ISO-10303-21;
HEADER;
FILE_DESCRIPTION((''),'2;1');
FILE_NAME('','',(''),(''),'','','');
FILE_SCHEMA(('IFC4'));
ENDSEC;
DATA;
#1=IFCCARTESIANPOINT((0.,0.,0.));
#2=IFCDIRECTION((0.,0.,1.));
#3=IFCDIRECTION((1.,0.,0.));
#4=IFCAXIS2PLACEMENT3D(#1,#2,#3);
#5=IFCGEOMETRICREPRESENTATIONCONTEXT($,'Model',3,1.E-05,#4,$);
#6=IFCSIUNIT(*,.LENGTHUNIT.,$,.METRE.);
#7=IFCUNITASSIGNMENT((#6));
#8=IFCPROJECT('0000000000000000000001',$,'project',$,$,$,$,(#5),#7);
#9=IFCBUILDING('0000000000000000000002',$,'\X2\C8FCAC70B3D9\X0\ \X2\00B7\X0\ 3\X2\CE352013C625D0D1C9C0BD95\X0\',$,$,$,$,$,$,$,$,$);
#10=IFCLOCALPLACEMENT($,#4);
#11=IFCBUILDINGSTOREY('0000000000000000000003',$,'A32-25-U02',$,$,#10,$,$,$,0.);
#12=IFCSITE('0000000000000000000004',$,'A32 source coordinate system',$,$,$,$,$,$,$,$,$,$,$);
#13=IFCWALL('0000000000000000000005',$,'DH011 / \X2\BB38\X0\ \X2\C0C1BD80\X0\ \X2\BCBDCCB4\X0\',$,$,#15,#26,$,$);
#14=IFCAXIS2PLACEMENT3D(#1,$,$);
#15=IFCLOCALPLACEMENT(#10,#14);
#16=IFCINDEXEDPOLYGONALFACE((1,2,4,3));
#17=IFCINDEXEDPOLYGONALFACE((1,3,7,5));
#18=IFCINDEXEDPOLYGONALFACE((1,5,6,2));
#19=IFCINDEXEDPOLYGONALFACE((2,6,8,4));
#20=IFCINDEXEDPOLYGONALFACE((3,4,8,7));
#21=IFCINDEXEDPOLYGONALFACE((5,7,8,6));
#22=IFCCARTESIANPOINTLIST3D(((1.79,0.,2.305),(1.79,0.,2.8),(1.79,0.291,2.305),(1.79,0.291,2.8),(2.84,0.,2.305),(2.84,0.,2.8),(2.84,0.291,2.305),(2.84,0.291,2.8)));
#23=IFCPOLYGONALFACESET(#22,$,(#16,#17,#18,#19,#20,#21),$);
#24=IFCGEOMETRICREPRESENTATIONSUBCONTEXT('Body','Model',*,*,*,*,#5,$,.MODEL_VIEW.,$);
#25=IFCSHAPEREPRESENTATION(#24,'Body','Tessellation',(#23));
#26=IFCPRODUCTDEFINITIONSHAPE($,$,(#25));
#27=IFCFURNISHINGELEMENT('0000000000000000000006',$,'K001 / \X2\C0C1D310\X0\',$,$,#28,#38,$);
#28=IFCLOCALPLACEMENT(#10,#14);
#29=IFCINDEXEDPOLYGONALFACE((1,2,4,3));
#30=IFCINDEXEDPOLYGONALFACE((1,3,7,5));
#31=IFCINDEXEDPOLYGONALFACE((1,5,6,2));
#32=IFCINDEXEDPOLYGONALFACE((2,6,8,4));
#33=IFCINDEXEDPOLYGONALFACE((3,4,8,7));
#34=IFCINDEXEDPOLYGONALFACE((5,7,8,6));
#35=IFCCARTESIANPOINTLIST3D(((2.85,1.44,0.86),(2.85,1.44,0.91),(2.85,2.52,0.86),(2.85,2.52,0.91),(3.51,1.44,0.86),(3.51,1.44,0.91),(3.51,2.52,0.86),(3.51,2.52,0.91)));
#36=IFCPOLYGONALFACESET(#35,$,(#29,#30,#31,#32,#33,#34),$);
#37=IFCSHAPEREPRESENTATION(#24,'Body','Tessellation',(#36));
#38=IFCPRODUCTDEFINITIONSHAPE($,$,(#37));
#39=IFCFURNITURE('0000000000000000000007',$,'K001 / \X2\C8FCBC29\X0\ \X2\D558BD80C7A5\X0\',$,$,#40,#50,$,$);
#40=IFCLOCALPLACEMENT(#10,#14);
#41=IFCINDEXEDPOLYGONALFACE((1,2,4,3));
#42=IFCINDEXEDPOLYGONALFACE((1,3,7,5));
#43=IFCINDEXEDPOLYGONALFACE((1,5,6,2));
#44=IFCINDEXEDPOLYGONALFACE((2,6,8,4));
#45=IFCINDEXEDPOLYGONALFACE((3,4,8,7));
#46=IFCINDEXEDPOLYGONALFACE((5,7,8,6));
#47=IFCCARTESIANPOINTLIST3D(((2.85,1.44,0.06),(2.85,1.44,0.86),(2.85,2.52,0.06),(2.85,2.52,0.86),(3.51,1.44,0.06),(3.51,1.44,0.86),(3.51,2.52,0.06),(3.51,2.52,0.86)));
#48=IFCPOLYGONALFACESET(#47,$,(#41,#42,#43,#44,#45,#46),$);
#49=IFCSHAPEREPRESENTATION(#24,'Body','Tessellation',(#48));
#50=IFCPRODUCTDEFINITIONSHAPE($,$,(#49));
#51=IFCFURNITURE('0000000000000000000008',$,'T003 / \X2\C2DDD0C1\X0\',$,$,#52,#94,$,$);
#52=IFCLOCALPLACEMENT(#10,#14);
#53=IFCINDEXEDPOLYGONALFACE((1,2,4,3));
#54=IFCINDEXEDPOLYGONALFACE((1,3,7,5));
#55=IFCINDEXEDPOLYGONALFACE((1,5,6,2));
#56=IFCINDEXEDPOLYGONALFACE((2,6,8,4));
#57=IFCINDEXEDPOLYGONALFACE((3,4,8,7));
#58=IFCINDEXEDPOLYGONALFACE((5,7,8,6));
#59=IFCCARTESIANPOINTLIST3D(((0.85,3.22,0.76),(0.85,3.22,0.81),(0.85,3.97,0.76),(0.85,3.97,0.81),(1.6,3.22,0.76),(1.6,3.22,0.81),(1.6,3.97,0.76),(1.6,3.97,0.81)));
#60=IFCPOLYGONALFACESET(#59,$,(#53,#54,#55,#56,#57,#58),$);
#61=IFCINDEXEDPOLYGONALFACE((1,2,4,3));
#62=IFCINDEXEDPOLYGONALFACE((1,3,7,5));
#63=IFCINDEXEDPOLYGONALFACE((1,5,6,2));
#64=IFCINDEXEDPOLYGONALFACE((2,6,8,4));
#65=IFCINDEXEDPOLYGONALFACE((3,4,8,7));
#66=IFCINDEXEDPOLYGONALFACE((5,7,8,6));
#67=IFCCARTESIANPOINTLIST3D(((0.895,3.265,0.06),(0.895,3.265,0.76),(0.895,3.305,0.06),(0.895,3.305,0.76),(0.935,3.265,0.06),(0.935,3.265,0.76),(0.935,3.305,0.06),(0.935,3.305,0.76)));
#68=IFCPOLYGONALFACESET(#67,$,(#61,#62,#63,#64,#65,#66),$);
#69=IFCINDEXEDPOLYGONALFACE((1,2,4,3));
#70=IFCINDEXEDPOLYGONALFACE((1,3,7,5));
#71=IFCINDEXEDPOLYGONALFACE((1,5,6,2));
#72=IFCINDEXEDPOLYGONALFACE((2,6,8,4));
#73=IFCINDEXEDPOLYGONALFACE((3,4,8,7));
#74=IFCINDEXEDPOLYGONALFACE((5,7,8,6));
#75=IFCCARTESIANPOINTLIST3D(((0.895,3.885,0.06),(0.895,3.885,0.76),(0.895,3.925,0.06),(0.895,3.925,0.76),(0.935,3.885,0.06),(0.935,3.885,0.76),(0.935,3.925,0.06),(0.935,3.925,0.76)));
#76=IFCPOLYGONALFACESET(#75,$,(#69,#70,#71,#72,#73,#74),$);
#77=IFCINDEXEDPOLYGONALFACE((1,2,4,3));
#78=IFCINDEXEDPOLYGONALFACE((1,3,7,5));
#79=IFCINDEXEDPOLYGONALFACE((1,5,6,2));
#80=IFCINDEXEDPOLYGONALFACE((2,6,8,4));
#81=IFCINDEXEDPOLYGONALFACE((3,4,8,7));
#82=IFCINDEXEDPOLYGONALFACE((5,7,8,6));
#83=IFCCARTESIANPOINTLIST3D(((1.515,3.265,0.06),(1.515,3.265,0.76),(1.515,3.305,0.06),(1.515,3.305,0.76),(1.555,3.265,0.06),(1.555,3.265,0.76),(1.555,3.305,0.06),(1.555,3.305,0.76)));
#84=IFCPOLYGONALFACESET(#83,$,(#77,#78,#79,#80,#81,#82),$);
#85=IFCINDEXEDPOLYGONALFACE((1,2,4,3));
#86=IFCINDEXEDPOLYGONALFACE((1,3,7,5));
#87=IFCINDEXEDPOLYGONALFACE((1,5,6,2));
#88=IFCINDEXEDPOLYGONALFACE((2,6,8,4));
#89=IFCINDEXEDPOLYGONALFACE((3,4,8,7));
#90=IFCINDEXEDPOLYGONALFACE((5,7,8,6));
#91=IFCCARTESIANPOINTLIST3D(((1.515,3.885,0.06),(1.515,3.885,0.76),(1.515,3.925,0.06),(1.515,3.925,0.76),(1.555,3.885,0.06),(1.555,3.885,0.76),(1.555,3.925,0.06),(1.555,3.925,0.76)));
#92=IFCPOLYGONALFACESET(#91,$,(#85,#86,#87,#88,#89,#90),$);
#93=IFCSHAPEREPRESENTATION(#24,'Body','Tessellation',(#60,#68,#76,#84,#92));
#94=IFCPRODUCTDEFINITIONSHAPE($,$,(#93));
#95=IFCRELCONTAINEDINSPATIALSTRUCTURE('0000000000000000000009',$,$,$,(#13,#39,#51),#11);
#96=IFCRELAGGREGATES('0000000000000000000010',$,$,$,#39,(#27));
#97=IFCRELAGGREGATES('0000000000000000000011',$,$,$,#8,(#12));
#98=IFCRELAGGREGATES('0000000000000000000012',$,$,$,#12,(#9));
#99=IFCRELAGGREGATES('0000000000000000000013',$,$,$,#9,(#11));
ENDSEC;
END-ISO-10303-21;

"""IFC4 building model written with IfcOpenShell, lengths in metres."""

from ifc_helpers import new_model, si_unit, frame, origin_with_axes, place, context, subcontext, project, spatial, polyline, outline, extrude, element, aggregate, save


model = new_model("IFC4")

# Units and contexts
model_context = context("Model", 3, precision=1e-05, world=origin_with_axes())
body_context = subcontext(model_context, "Body", "Model", "MODEL_VIEW")
ifc_project = project(units=[si_unit("LENGTHUNIT", "METRE")], contexts=[model_context])

# Site, building, storey
site = spatial("IfcSite", under=ifc_project, Name="A32 source coordinate system")
building = spatial("IfcBuilding", under=site, Name="주거동 · 3층–옥탑지붕")
storey_placement = place(None, origin_with_axes())
storey = spatial("IfcBuildingStorey", under=building, at=storey_placement, Name="A32-25-U02", Elevation=0.0)

# Wall
wall_1_placement = place(storey_placement, origin_with_axes())
element("IfcWall", 1, at=wall_1_placement, inside=storey, Name="DH011 / 문 상부 벽체", context=body_context, shape_type="SweptSolid", body=[
    extrude(outline(polyline([(2.84, 0.0), (1.79, 0.0), (1.79, 0.291), (2.84, 0.291), (2.84, 0.0)])), frame((0.0, 0.0, 2.305)), (0.0, 0.0, 1.0), 0.495),
])

# Furnishing element
furniture_1_placement = place(storey_placement, origin_with_axes())
furnishing_1_placement = place(furniture_1_placement, origin_with_axes())
furnishing_1 = element("IfcFurnishingElement", 2, at=furnishing_1_placement, Name="K001 / 상판", context=body_context, shape_type="SweptSolid", body=[
    extrude(outline(polyline([(2.85, 2.52), (3.51, 2.52), (3.51, 1.44), (2.85, 1.44), (2.85, 2.52)])), frame((0.0, 0.0, 0.86)), (0.0, 0.0, 1.0), 0.05),
])

# Furniture
furniture_1 = element("IfcFurniture", 3, at=furniture_1_placement, inside=storey, Name="K001 / 주방 하부장", context=body_context, shape_type="SweptSolid", body=[
    extrude(outline(polyline([(2.85, 1.44), (2.85, 2.52), (3.51, 2.52), (3.51, 1.44), (2.85, 1.44)])), frame((0.0, 0.0, 0.06)), (0.0, 0.0, 1.0), 0.8),
])
aggregate(furniture_1, [furnishing_1])
furniture_2_placement = place(storey_placement, origin_with_axes())
element("IfcFurniture", 4, at=furniture_2_placement, inside=storey, Name="T003 / 식탁", context=body_context, shape_type="SweptSolid", body=[
    extrude(outline(polyline([(1.6, 3.97), (1.6, 3.22), (0.85, 3.22), (0.85, 3.97), (1.6, 3.97)])), frame((0.0, 0.0, 0.76)), (0.0, 0.0, 1.0), 0.05),
    extrude(outline(polyline([(0.895, 3.265), (0.895, 3.305), (0.935, 3.305), (0.935, 3.265), (0.895, 3.265)])), frame((0.0, 0.0, 0.06)), (0.0, 0.0, 1.0), 0.7),
    extrude(outline(polyline([(0.895, 3.885), (0.895, 3.925), (0.935, 3.925), (0.935, 3.885), (0.895, 3.885)])), frame((0.0, 0.0, 0.06)), (0.0, 0.0, 1.0), 0.7),
    extrude(outline(polyline([(1.515, 3.265), (1.515, 3.305), (1.555, 3.305), (1.555, 3.265), (1.515, 3.265)])), frame((0.0, 0.0, 0.06)), (0.0, 0.0, 1.0), 0.7),
    extrude(outline(polyline([(1.515, 3.885), (1.515, 3.925), (1.555, 3.925), (1.555, 3.885), (1.515, 3.885)])), frame((0.0, 0.0, 0.06)), (0.0, 0.0, 1.0), 0.7),
])

save(model, "model.ifc")
